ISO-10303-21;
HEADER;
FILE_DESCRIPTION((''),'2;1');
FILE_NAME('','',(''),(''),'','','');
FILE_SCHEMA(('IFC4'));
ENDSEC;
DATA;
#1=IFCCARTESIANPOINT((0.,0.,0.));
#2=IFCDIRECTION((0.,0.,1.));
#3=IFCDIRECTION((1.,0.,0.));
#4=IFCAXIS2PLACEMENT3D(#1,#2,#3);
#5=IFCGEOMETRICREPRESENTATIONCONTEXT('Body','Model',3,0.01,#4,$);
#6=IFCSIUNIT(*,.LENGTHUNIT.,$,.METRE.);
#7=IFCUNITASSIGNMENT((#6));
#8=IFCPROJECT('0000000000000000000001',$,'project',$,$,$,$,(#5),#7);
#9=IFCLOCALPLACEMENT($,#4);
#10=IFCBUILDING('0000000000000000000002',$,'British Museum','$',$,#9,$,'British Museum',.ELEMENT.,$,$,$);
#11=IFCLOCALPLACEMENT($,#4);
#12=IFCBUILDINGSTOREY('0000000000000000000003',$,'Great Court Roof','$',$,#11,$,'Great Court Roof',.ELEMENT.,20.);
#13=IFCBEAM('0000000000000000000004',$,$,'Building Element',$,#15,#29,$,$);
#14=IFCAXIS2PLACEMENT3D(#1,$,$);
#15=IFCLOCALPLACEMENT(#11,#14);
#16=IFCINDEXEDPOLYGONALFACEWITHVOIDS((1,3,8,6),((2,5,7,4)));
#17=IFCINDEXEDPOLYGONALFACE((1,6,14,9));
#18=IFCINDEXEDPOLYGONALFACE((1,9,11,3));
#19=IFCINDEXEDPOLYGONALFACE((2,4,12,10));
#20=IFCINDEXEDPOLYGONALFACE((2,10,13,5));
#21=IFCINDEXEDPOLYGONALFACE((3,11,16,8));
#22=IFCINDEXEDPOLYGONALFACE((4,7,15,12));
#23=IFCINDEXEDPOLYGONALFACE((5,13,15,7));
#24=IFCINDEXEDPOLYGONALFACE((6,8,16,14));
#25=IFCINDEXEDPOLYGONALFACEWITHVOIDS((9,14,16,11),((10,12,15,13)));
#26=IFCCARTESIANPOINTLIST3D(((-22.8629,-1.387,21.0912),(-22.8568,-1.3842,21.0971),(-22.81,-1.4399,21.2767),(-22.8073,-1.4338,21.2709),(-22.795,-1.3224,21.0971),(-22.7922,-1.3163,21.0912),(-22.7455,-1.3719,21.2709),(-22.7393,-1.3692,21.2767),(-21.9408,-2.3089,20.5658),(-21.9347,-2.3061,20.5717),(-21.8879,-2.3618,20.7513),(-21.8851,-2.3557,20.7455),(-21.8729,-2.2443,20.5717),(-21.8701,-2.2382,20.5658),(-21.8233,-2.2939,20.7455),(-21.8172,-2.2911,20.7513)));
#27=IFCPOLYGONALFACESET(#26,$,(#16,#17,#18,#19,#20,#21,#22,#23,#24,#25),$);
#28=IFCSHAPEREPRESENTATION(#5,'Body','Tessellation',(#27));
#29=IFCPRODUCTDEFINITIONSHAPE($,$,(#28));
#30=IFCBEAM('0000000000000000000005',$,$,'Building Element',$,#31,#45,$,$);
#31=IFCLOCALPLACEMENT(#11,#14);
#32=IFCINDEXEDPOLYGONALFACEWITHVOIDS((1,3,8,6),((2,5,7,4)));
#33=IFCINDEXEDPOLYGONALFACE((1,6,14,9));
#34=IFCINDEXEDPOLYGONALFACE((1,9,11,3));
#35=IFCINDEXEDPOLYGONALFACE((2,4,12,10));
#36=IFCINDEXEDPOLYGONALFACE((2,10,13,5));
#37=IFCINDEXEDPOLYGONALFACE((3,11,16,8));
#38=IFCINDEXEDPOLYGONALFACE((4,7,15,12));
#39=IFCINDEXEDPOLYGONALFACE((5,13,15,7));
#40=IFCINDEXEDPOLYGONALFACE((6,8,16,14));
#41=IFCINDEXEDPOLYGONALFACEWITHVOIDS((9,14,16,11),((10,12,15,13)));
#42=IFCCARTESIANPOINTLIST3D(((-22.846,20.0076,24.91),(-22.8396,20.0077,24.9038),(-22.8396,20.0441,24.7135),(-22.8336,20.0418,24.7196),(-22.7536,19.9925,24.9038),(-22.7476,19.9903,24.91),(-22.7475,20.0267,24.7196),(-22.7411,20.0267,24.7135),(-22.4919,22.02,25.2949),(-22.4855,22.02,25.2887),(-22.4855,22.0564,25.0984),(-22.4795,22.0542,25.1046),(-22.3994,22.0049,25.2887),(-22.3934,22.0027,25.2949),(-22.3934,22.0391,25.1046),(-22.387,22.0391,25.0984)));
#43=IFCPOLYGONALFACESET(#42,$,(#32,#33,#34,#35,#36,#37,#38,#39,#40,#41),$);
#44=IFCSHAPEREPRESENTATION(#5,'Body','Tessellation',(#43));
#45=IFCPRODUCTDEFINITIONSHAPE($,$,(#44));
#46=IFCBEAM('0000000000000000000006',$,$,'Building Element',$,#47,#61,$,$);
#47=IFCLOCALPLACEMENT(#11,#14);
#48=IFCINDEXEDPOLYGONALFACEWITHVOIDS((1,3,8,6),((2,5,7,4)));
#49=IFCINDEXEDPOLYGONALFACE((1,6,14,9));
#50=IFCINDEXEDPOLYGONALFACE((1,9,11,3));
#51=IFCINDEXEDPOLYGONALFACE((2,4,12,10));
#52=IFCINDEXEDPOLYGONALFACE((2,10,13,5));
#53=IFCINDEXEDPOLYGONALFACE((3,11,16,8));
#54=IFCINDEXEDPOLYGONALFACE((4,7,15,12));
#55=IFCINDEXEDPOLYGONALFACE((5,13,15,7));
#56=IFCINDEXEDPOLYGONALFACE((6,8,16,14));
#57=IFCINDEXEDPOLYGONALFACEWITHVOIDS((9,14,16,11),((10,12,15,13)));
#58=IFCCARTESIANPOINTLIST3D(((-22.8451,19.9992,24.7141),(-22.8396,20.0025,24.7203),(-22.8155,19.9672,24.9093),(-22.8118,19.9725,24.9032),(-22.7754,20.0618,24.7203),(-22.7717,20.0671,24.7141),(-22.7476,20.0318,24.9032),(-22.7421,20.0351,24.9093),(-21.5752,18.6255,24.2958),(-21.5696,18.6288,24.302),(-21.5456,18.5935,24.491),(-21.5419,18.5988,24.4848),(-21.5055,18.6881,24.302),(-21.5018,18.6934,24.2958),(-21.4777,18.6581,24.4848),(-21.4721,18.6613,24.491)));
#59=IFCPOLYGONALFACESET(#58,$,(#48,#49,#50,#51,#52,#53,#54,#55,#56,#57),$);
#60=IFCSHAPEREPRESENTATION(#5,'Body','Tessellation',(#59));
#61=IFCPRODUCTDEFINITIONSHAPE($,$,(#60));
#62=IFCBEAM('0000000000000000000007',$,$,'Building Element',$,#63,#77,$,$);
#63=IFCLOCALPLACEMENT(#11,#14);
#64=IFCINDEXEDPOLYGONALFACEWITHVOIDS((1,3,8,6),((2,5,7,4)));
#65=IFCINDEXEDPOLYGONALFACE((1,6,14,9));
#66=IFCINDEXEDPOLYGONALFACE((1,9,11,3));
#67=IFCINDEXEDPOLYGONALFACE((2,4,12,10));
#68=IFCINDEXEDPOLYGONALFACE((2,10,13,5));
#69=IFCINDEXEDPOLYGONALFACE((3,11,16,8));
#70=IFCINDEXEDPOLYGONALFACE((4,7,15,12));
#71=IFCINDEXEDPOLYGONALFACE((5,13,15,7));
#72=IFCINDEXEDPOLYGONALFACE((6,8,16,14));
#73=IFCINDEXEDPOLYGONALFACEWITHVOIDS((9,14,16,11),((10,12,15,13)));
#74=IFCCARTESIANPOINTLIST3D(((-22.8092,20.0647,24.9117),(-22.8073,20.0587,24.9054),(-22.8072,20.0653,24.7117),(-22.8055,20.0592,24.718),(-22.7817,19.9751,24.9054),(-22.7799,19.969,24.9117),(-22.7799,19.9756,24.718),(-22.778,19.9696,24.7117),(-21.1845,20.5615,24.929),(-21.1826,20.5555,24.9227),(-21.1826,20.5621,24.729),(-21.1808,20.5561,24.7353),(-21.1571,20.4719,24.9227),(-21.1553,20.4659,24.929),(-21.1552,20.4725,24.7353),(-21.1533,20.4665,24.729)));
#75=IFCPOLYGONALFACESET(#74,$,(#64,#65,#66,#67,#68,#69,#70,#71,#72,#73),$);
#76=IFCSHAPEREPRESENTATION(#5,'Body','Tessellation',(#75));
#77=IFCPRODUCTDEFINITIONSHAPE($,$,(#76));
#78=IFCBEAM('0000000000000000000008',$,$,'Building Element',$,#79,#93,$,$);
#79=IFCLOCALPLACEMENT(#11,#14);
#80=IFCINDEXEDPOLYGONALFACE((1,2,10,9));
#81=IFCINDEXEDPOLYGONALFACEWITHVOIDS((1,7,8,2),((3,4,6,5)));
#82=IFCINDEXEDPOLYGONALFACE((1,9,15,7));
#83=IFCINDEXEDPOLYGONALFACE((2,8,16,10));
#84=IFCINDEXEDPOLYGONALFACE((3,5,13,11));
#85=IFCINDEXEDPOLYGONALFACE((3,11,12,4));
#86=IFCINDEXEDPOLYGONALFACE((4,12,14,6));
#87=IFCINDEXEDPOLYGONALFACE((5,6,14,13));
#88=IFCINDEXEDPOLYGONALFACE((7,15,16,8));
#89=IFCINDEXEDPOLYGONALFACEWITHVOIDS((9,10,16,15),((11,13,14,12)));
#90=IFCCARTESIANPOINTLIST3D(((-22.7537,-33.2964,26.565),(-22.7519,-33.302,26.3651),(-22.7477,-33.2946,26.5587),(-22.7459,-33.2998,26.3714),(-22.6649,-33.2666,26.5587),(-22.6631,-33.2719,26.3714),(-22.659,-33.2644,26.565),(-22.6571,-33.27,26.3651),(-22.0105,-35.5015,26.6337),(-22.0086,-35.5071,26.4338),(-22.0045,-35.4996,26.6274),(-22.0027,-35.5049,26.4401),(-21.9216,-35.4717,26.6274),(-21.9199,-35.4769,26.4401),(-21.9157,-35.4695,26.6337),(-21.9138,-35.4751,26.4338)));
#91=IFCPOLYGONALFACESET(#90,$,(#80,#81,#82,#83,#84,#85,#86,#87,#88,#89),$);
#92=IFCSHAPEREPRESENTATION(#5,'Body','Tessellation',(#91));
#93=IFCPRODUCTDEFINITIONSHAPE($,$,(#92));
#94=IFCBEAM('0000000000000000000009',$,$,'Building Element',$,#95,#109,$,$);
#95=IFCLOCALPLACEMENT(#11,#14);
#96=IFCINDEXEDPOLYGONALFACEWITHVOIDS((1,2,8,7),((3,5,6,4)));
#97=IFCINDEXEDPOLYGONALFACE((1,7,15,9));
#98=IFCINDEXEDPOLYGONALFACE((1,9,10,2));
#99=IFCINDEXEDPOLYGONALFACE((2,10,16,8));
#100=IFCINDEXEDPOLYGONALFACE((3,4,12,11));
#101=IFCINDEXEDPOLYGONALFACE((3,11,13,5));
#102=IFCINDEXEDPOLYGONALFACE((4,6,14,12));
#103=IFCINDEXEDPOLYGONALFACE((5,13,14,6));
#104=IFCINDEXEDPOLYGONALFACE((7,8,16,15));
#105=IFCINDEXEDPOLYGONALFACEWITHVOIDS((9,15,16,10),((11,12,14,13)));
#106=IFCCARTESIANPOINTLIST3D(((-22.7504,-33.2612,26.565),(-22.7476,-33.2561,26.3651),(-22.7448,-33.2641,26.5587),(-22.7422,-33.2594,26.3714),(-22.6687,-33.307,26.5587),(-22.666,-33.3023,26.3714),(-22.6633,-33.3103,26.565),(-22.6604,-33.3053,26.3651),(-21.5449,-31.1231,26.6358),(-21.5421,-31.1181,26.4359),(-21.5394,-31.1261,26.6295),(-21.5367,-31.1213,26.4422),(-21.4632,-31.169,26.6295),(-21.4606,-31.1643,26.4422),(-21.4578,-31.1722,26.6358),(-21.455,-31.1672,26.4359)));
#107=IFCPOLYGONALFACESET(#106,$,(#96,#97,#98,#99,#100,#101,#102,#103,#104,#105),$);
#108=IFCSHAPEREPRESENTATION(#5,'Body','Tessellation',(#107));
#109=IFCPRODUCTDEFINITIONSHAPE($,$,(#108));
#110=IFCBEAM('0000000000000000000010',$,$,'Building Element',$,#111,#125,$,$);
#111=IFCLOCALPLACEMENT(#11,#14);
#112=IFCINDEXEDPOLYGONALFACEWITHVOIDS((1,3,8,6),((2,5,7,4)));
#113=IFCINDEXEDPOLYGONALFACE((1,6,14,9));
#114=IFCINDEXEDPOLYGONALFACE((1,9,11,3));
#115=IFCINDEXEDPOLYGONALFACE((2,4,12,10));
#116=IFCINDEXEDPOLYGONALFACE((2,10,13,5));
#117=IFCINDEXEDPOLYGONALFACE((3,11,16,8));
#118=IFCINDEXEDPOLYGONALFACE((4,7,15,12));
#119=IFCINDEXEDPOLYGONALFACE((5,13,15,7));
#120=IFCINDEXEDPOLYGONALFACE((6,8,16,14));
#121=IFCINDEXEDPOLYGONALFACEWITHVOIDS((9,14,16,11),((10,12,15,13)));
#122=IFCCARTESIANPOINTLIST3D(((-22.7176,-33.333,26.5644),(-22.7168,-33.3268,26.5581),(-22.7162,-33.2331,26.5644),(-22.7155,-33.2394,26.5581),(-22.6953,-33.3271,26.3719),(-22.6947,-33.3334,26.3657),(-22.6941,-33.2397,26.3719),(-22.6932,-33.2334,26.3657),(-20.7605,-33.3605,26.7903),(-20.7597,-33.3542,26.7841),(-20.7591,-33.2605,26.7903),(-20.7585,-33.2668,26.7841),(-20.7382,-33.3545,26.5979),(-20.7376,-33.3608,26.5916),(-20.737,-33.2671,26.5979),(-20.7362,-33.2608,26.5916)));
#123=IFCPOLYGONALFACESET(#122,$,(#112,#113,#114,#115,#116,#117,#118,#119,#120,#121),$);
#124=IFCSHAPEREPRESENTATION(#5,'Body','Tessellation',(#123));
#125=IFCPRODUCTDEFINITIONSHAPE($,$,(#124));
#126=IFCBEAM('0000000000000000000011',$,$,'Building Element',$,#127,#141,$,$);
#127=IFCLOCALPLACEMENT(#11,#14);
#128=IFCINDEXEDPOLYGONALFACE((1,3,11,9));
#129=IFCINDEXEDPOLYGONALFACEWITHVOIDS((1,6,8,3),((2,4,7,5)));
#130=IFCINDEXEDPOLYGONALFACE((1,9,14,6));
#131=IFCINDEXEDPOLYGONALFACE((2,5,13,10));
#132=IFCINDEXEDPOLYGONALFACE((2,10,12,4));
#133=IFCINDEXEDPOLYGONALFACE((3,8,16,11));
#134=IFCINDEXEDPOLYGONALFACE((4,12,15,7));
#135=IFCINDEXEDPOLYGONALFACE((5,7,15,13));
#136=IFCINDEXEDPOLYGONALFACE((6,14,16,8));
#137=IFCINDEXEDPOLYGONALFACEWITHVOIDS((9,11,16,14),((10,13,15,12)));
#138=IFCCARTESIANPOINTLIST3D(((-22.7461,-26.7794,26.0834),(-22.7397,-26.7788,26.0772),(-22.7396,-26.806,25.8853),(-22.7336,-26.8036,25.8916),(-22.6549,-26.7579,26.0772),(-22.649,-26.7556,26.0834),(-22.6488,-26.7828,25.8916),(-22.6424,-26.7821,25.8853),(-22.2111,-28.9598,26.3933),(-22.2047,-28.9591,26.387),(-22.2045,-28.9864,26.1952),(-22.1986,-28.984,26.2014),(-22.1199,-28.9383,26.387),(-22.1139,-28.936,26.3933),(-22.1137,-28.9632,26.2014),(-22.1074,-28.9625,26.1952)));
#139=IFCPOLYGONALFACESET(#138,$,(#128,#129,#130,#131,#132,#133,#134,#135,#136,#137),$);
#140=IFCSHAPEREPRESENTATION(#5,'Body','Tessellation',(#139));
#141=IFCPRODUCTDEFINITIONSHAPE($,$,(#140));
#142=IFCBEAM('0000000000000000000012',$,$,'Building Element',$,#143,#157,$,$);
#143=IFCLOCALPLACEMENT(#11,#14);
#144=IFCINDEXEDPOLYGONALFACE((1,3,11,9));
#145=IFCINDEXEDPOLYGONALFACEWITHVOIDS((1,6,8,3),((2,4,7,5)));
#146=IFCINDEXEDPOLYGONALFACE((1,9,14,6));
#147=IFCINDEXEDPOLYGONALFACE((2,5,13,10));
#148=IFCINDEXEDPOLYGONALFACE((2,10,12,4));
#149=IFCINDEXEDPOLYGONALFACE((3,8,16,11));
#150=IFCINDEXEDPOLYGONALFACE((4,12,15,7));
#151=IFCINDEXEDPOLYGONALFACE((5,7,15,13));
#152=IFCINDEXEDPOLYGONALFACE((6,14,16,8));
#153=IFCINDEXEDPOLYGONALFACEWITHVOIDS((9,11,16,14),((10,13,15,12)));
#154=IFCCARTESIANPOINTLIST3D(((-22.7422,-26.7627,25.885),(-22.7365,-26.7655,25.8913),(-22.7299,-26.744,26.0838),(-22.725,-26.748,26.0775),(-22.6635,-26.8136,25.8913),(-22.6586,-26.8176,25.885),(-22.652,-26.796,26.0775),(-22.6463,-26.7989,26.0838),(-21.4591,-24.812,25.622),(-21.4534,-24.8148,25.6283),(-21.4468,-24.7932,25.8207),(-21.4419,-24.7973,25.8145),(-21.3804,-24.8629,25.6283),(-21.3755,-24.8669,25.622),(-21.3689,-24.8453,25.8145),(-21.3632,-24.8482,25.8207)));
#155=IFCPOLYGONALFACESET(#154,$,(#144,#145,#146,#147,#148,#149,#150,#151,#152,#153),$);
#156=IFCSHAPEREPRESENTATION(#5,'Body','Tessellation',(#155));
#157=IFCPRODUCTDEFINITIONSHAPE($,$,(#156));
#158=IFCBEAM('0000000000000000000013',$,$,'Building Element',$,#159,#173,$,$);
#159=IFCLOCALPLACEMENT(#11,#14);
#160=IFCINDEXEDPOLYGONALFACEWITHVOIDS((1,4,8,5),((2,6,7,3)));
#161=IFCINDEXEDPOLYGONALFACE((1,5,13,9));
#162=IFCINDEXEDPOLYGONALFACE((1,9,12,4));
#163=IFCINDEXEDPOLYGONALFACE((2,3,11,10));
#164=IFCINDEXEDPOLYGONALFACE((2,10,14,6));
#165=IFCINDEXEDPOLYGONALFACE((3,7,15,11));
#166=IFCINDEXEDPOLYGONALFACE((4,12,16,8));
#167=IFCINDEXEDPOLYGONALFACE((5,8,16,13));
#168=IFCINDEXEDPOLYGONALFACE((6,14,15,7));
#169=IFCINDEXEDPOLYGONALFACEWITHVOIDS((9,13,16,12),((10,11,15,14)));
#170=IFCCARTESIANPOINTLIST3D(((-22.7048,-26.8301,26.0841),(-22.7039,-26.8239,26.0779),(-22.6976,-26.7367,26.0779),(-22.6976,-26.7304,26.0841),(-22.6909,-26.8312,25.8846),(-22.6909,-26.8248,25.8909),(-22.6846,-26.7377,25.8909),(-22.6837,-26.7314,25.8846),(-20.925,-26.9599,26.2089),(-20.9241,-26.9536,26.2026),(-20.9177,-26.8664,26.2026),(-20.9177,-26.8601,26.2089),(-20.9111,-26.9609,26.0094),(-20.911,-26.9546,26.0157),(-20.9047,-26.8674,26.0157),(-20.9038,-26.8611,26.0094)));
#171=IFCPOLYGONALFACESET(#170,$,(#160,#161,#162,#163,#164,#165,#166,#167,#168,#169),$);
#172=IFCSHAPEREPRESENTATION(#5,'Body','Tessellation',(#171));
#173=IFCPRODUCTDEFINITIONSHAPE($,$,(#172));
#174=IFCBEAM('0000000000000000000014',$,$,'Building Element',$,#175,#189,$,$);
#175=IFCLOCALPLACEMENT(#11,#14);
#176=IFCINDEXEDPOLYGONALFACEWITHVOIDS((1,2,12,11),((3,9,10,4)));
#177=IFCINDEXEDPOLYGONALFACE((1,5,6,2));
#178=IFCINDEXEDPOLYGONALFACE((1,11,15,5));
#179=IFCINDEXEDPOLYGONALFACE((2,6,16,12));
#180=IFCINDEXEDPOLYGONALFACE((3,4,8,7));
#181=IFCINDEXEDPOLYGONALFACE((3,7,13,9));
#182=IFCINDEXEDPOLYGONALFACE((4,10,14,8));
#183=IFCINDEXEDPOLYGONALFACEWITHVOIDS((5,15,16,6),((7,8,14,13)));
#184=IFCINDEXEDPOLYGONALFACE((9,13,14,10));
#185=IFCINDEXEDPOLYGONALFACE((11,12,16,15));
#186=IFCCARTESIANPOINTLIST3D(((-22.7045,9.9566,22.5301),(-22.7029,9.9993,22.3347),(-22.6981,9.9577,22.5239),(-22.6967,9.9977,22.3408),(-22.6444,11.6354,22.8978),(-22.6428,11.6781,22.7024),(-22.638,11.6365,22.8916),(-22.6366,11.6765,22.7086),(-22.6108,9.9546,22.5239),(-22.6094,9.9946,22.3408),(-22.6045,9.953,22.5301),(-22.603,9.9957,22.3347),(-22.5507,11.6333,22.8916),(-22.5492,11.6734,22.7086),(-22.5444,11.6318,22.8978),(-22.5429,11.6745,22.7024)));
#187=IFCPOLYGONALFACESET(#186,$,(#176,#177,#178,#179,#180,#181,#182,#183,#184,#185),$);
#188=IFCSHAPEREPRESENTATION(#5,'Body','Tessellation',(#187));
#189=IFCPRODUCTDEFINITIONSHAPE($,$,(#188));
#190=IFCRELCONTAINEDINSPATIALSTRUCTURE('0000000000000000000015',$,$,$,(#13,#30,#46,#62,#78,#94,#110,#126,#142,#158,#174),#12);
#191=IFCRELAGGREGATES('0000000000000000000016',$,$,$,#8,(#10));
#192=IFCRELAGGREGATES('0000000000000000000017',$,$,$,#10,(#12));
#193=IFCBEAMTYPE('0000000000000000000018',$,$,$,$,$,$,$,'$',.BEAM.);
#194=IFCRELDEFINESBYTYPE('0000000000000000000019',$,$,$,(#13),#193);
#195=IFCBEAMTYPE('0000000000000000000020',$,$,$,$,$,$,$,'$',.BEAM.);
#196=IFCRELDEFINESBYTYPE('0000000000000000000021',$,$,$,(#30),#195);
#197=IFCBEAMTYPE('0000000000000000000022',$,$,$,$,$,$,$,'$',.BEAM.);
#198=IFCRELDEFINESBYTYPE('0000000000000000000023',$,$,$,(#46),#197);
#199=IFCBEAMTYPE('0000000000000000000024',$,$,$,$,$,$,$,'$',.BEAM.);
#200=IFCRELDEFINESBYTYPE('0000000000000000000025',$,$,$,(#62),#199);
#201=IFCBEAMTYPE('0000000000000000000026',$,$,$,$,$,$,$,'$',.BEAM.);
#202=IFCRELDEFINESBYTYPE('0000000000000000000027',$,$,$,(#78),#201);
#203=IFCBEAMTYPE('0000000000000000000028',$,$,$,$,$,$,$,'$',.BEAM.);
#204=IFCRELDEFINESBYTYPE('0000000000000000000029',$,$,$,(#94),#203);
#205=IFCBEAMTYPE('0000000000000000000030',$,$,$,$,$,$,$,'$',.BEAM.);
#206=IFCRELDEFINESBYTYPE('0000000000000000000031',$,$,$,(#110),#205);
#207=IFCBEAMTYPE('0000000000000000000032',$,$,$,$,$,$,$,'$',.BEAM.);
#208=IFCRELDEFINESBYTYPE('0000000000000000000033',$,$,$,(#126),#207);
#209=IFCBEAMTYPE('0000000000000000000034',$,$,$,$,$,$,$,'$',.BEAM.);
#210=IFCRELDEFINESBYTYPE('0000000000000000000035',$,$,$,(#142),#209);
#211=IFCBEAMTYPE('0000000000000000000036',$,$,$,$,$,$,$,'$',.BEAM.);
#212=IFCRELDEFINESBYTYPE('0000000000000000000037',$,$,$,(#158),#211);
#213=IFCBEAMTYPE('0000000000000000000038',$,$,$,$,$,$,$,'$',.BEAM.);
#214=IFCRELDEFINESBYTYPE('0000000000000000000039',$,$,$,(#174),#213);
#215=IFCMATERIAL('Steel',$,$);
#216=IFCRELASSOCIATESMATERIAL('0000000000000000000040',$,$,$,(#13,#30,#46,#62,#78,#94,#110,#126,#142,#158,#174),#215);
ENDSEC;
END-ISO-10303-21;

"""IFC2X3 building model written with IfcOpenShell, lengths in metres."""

from ifc_helpers import new_model, si_unit, frame, origin_with_axes, origin_2d, place, context, project, spatial, hollow_rectangle, extrude, material, type_object, element, save


model = new_model("IFC2X3")

# Units and contexts
model_context = context("Model", 3, precision=0.01, world=origin_with_axes(), identifier="Body")
ifc_project = project(units=[si_unit("LENGTHUNIT", "METRE")], contexts=[model_context])

# Building, storey
building_placement = place(None, origin_with_axes())
building = spatial("IfcBuilding", under=ifc_project, at=building_placement, Name="British Museum", Description="$", LongName="British Museum", CompositionType="ELEMENT")
storey_placement = place(None, origin_with_axes())
storey = spatial("IfcBuildingStorey", under=building, at=storey_placement, Name="Great Court Roof", Description="$", LongName="Great Court Roof", CompositionType="ELEMENT", Elevation=20.0)

# Beams
ifc_material = material(Name="Steel")
beam_type_1 = type_object("IfcBeamType", ElementType="$", PredefinedType="BEAM")
beam_1_placement = place(None, origin_with_axes())
element("IfcBeam", 1, at=beam_1_placement, inside=storey, type_object=beam_type_1, material=ifc_material, Description="Building Element", context=model_context, shape_type="SweptSolid", body=[
    extrude(hollow_rectangle(XDim=0.1, YDim=0.2, WallThickness=0.0063, InnerFilletRadius=-0.0063, OuterFilletRadius=0.0, at=origin_2d()), frame((-22.8011, -1.3781, 21.184), z_axis=(0.655939, -0.655789, -0.373745), x_axis=(0.707026, 0.707188, 0.0)), (0.0, 0.0, 1.0), 1.4058),
])
beam_type_2 = type_object("IfcBeamType", ElementType="$", PredefinedType="BEAM")
beam_2_placement = place(None, origin_with_axes())
element("IfcBeam", 2, at=beam_2_placement, inside=storey, type_object=beam_type_2, material=ifc_material, Description="Building Element", context=model_context, shape_type="SweptSolid", body=[
    extrude(hollow_rectangle(XDim=0.1, YDim=0.2, WallThickness=0.0063, InnerFilletRadius=-0.0063, OuterFilletRadius=0.0, at=origin_2d()), frame((-22.7936, 20.0172, 24.8117), z_axis=(0.170321, 0.967842, 0.185126), x_axis=(-0.984866, 0.173317, 0.0)), (0.0, 0.0, 1.0), 2.0793),
])
beam_type_3 = type_object("IfcBeamType", ElementType="$", PredefinedType="BEAM")
beam_3_placement = place(None, origin_with_axes())
element("IfcBeam", 3, at=beam_3_placement, inside=storey, type_object=beam_type_3, material=ifc_material, Description="Building Element", context=model_context, shape_type="SweptSolid", body=[
    extrude(hollow_rectangle(XDim=0.1, YDim=0.2, WallThickness=0.0063, InnerFilletRadius=-0.0063, OuterFilletRadius=0.0, at=origin_2d()), frame((-22.7936, 20.0172, 24.8117), z_axis=(0.662455, -0.716611, -0.218223), x_axis=(0.734309, 0.678815, 0.0)), (0.0, 0.0, 1.0), 1.917),
])
beam_type_4 = type_object("IfcBeamType", ElementType="$", PredefinedType="BEAM")
beam_4_placement = place(None, origin_with_axes())
element("IfcBeam", 4, at=beam_4_placement, inside=storey, type_object=beam_type_4, material=ifc_material, Description="Building Element", context=model_context, shape_type="SweptSolid", body=[
    extrude(hollow_rectangle(XDim=0.1, YDim=0.2, WallThickness=0.0063, InnerFilletRadius=-0.0063, OuterFilletRadius=0.0, at=origin_2d()), frame((-22.7936, 20.0172, 24.8117), z_axis=(0.956233, 0.292429, 0.010158), x_axis=(-0.292444, 0.956283, 0.0)), (0.0, 0.0, 1.0), 1.699),
])
beam_type_5 = type_object("IfcBeamType", ElementType="$", PredefinedType="BEAM")
beam_5_placement = place(None, origin_with_axes())
element("IfcBeam", 5, at=beam_5_placement, inside=storey, type_object=beam_type_5, material=ifc_material, Description="Building Element", context=model_context, shape_type="SweptSolid", body=[
    extrude(hollow_rectangle(XDim=0.1, YDim=0.2, WallThickness=0.0063, InnerFilletRadius=-0.0063, OuterFilletRadius=0.0, at=origin_2d()), frame((-22.7054, -33.2832, 26.465), z_axis=(0.319272, -0.947204, 0.029513), x_axis=(0.947616, 0.319411, 0.0)), (0.0, 0.0, 1.0), 2.328),
])
beam_type_6 = type_object("IfcBeamType", ElementType="$", PredefinedType="BEAM")
beam_6_placement = place(None, origin_with_axes())
element("IfcBeam", 6, at=beam_6_placement, inside=storey, type_object=beam_type_6, material=ifc_material, Description="Building Element", context=model_context, shape_type="SweptSolid", body=[
    extrude(hollow_rectangle(XDim=0.1, YDim=0.2, WallThickness=0.0063, InnerFilletRadius=-0.0063, OuterFilletRadius=0.0, at=origin_2d()), frame((-22.7054, -33.2832, 26.465), z_axis=(0.490921, 0.870726, 0.028847), x_axis=(-0.871089, 0.491126, 0.0)), (0.0, 0.0, 1.0), 2.4555),
])
beam_type_7 = type_object("IfcBeamType", ElementType="$", PredefinedType="BEAM")
beam_7_placement = place(None, origin_with_axes())
element("IfcBeam", 7, at=beam_7_placement, inside=storey, type_object=beam_type_7, material=ifc_material, Description="Building Element", context=model_context, shape_type="SweptSolid", body=[
    extrude(hollow_rectangle(XDim=0.1, YDim=0.2, WallThickness=0.0063, InnerFilletRadius=-0.0063, OuterFilletRadius=0.0, at=origin_2d()), frame((-22.7054, -33.2832, 26.465), z_axis=(0.993304, -0.013938, 0.114682), x_axis=(0.014031, 0.999902, 0.0)), (0.0, 0.0, 1.0), 1.9703),
])
beam_type_8 = type_object("IfcBeamType", ElementType="$", PredefinedType="BEAM")
beam_8_placement = place(None, origin_with_axes())
element("IfcBeam", 8, at=beam_8_placement, inside=storey, type_object=beam_type_8, material=ifc_material, Description="Building Element", context=model_context, shape_type="SweptSolid", body=[
    extrude(hollow_rectangle(XDim=0.1, YDim=0.2, WallThickness=0.0063, InnerFilletRadius=-0.0063, OuterFilletRadius=0.0, at=origin_2d()), frame((-22.6943, -26.7808, 25.9844), z_axis=(0.236068, -0.962071, 0.136713), x_axis=(0.97119, 0.238306, 0.0)), (0.0, 0.0, 1.0), 2.2663),
])
beam_type_9 = type_object("IfcBeamType", ElementType="$", PredefinedType="BEAM")
beam_9_placement = place(None, origin_with_axes())
element("IfcBeam", 9, at=beam_9_placement, inside=storey, type_object=beam_type_9, material=ifc_material, Description="Building Element", context=model_context, shape_type="SweptSolid", body=[
    extrude(hollow_rectangle(XDim=0.1, YDim=0.2, WallThickness=0.0063, InnerFilletRadius=-0.0063, OuterFilletRadius=0.0, at=origin_2d()), frame((-22.6943, -26.7808, 25.9844), z_axis=(0.546091, 0.830214, -0.111936), x_axis=(-0.835464, 0.549545, 0.0)), (0.0, 0.0, 1.0), 2.3496),
])
beam_type_10 = type_object("IfcBeamType", ElementType="$", PredefinedType="BEAM")
beam_10_placement = place(None, origin_with_axes())
element("IfcBeam", 10, at=beam_10_placement, inside=storey, type_object=beam_type_10, material=ifc_material, Description="Building Element", context=model_context, shape_type="SweptSolid", body=[
    extrude(hollow_rectangle(XDim=0.1, YDim=0.2, WallThickness=0.0063, InnerFilletRadius=-0.0063, OuterFilletRadius=0.0, at=origin_2d()), frame((-22.6943, -26.7808, 25.9844), z_axis=(0.994926, -0.072508, 0.069745), x_axis=(0.072685, 0.997355, 0.0)), (0.0, 0.0, 1.0), 1.789),
])
beam_type_11 = type_object("IfcBeamType", ElementType="$", PredefinedType="BEAM")
beam_11_placement = place(None, origin_with_axes())
element("IfcBeam", 11, at=beam_11_placement, inside=storey, type_object=beam_type_11, material=ifc_material, Description="Building Element", context=model_context, shape_type="SweptSolid", body=[
    extrude(hollow_rectangle(XDim=0.1, YDim=0.2, WallThickness=0.0063, InnerFilletRadius=-0.0063, OuterFilletRadius=0.0, at=origin_2d()), frame((-22.6537, 9.9762, 22.4324), z_axis=(0.034951, 0.976242, 0.213846), x_axis=(-0.99936, 0.035779, 0.0)), (0.0, 0.0, 1.0), 1.7196),
])

save(model, "model.ifc")
